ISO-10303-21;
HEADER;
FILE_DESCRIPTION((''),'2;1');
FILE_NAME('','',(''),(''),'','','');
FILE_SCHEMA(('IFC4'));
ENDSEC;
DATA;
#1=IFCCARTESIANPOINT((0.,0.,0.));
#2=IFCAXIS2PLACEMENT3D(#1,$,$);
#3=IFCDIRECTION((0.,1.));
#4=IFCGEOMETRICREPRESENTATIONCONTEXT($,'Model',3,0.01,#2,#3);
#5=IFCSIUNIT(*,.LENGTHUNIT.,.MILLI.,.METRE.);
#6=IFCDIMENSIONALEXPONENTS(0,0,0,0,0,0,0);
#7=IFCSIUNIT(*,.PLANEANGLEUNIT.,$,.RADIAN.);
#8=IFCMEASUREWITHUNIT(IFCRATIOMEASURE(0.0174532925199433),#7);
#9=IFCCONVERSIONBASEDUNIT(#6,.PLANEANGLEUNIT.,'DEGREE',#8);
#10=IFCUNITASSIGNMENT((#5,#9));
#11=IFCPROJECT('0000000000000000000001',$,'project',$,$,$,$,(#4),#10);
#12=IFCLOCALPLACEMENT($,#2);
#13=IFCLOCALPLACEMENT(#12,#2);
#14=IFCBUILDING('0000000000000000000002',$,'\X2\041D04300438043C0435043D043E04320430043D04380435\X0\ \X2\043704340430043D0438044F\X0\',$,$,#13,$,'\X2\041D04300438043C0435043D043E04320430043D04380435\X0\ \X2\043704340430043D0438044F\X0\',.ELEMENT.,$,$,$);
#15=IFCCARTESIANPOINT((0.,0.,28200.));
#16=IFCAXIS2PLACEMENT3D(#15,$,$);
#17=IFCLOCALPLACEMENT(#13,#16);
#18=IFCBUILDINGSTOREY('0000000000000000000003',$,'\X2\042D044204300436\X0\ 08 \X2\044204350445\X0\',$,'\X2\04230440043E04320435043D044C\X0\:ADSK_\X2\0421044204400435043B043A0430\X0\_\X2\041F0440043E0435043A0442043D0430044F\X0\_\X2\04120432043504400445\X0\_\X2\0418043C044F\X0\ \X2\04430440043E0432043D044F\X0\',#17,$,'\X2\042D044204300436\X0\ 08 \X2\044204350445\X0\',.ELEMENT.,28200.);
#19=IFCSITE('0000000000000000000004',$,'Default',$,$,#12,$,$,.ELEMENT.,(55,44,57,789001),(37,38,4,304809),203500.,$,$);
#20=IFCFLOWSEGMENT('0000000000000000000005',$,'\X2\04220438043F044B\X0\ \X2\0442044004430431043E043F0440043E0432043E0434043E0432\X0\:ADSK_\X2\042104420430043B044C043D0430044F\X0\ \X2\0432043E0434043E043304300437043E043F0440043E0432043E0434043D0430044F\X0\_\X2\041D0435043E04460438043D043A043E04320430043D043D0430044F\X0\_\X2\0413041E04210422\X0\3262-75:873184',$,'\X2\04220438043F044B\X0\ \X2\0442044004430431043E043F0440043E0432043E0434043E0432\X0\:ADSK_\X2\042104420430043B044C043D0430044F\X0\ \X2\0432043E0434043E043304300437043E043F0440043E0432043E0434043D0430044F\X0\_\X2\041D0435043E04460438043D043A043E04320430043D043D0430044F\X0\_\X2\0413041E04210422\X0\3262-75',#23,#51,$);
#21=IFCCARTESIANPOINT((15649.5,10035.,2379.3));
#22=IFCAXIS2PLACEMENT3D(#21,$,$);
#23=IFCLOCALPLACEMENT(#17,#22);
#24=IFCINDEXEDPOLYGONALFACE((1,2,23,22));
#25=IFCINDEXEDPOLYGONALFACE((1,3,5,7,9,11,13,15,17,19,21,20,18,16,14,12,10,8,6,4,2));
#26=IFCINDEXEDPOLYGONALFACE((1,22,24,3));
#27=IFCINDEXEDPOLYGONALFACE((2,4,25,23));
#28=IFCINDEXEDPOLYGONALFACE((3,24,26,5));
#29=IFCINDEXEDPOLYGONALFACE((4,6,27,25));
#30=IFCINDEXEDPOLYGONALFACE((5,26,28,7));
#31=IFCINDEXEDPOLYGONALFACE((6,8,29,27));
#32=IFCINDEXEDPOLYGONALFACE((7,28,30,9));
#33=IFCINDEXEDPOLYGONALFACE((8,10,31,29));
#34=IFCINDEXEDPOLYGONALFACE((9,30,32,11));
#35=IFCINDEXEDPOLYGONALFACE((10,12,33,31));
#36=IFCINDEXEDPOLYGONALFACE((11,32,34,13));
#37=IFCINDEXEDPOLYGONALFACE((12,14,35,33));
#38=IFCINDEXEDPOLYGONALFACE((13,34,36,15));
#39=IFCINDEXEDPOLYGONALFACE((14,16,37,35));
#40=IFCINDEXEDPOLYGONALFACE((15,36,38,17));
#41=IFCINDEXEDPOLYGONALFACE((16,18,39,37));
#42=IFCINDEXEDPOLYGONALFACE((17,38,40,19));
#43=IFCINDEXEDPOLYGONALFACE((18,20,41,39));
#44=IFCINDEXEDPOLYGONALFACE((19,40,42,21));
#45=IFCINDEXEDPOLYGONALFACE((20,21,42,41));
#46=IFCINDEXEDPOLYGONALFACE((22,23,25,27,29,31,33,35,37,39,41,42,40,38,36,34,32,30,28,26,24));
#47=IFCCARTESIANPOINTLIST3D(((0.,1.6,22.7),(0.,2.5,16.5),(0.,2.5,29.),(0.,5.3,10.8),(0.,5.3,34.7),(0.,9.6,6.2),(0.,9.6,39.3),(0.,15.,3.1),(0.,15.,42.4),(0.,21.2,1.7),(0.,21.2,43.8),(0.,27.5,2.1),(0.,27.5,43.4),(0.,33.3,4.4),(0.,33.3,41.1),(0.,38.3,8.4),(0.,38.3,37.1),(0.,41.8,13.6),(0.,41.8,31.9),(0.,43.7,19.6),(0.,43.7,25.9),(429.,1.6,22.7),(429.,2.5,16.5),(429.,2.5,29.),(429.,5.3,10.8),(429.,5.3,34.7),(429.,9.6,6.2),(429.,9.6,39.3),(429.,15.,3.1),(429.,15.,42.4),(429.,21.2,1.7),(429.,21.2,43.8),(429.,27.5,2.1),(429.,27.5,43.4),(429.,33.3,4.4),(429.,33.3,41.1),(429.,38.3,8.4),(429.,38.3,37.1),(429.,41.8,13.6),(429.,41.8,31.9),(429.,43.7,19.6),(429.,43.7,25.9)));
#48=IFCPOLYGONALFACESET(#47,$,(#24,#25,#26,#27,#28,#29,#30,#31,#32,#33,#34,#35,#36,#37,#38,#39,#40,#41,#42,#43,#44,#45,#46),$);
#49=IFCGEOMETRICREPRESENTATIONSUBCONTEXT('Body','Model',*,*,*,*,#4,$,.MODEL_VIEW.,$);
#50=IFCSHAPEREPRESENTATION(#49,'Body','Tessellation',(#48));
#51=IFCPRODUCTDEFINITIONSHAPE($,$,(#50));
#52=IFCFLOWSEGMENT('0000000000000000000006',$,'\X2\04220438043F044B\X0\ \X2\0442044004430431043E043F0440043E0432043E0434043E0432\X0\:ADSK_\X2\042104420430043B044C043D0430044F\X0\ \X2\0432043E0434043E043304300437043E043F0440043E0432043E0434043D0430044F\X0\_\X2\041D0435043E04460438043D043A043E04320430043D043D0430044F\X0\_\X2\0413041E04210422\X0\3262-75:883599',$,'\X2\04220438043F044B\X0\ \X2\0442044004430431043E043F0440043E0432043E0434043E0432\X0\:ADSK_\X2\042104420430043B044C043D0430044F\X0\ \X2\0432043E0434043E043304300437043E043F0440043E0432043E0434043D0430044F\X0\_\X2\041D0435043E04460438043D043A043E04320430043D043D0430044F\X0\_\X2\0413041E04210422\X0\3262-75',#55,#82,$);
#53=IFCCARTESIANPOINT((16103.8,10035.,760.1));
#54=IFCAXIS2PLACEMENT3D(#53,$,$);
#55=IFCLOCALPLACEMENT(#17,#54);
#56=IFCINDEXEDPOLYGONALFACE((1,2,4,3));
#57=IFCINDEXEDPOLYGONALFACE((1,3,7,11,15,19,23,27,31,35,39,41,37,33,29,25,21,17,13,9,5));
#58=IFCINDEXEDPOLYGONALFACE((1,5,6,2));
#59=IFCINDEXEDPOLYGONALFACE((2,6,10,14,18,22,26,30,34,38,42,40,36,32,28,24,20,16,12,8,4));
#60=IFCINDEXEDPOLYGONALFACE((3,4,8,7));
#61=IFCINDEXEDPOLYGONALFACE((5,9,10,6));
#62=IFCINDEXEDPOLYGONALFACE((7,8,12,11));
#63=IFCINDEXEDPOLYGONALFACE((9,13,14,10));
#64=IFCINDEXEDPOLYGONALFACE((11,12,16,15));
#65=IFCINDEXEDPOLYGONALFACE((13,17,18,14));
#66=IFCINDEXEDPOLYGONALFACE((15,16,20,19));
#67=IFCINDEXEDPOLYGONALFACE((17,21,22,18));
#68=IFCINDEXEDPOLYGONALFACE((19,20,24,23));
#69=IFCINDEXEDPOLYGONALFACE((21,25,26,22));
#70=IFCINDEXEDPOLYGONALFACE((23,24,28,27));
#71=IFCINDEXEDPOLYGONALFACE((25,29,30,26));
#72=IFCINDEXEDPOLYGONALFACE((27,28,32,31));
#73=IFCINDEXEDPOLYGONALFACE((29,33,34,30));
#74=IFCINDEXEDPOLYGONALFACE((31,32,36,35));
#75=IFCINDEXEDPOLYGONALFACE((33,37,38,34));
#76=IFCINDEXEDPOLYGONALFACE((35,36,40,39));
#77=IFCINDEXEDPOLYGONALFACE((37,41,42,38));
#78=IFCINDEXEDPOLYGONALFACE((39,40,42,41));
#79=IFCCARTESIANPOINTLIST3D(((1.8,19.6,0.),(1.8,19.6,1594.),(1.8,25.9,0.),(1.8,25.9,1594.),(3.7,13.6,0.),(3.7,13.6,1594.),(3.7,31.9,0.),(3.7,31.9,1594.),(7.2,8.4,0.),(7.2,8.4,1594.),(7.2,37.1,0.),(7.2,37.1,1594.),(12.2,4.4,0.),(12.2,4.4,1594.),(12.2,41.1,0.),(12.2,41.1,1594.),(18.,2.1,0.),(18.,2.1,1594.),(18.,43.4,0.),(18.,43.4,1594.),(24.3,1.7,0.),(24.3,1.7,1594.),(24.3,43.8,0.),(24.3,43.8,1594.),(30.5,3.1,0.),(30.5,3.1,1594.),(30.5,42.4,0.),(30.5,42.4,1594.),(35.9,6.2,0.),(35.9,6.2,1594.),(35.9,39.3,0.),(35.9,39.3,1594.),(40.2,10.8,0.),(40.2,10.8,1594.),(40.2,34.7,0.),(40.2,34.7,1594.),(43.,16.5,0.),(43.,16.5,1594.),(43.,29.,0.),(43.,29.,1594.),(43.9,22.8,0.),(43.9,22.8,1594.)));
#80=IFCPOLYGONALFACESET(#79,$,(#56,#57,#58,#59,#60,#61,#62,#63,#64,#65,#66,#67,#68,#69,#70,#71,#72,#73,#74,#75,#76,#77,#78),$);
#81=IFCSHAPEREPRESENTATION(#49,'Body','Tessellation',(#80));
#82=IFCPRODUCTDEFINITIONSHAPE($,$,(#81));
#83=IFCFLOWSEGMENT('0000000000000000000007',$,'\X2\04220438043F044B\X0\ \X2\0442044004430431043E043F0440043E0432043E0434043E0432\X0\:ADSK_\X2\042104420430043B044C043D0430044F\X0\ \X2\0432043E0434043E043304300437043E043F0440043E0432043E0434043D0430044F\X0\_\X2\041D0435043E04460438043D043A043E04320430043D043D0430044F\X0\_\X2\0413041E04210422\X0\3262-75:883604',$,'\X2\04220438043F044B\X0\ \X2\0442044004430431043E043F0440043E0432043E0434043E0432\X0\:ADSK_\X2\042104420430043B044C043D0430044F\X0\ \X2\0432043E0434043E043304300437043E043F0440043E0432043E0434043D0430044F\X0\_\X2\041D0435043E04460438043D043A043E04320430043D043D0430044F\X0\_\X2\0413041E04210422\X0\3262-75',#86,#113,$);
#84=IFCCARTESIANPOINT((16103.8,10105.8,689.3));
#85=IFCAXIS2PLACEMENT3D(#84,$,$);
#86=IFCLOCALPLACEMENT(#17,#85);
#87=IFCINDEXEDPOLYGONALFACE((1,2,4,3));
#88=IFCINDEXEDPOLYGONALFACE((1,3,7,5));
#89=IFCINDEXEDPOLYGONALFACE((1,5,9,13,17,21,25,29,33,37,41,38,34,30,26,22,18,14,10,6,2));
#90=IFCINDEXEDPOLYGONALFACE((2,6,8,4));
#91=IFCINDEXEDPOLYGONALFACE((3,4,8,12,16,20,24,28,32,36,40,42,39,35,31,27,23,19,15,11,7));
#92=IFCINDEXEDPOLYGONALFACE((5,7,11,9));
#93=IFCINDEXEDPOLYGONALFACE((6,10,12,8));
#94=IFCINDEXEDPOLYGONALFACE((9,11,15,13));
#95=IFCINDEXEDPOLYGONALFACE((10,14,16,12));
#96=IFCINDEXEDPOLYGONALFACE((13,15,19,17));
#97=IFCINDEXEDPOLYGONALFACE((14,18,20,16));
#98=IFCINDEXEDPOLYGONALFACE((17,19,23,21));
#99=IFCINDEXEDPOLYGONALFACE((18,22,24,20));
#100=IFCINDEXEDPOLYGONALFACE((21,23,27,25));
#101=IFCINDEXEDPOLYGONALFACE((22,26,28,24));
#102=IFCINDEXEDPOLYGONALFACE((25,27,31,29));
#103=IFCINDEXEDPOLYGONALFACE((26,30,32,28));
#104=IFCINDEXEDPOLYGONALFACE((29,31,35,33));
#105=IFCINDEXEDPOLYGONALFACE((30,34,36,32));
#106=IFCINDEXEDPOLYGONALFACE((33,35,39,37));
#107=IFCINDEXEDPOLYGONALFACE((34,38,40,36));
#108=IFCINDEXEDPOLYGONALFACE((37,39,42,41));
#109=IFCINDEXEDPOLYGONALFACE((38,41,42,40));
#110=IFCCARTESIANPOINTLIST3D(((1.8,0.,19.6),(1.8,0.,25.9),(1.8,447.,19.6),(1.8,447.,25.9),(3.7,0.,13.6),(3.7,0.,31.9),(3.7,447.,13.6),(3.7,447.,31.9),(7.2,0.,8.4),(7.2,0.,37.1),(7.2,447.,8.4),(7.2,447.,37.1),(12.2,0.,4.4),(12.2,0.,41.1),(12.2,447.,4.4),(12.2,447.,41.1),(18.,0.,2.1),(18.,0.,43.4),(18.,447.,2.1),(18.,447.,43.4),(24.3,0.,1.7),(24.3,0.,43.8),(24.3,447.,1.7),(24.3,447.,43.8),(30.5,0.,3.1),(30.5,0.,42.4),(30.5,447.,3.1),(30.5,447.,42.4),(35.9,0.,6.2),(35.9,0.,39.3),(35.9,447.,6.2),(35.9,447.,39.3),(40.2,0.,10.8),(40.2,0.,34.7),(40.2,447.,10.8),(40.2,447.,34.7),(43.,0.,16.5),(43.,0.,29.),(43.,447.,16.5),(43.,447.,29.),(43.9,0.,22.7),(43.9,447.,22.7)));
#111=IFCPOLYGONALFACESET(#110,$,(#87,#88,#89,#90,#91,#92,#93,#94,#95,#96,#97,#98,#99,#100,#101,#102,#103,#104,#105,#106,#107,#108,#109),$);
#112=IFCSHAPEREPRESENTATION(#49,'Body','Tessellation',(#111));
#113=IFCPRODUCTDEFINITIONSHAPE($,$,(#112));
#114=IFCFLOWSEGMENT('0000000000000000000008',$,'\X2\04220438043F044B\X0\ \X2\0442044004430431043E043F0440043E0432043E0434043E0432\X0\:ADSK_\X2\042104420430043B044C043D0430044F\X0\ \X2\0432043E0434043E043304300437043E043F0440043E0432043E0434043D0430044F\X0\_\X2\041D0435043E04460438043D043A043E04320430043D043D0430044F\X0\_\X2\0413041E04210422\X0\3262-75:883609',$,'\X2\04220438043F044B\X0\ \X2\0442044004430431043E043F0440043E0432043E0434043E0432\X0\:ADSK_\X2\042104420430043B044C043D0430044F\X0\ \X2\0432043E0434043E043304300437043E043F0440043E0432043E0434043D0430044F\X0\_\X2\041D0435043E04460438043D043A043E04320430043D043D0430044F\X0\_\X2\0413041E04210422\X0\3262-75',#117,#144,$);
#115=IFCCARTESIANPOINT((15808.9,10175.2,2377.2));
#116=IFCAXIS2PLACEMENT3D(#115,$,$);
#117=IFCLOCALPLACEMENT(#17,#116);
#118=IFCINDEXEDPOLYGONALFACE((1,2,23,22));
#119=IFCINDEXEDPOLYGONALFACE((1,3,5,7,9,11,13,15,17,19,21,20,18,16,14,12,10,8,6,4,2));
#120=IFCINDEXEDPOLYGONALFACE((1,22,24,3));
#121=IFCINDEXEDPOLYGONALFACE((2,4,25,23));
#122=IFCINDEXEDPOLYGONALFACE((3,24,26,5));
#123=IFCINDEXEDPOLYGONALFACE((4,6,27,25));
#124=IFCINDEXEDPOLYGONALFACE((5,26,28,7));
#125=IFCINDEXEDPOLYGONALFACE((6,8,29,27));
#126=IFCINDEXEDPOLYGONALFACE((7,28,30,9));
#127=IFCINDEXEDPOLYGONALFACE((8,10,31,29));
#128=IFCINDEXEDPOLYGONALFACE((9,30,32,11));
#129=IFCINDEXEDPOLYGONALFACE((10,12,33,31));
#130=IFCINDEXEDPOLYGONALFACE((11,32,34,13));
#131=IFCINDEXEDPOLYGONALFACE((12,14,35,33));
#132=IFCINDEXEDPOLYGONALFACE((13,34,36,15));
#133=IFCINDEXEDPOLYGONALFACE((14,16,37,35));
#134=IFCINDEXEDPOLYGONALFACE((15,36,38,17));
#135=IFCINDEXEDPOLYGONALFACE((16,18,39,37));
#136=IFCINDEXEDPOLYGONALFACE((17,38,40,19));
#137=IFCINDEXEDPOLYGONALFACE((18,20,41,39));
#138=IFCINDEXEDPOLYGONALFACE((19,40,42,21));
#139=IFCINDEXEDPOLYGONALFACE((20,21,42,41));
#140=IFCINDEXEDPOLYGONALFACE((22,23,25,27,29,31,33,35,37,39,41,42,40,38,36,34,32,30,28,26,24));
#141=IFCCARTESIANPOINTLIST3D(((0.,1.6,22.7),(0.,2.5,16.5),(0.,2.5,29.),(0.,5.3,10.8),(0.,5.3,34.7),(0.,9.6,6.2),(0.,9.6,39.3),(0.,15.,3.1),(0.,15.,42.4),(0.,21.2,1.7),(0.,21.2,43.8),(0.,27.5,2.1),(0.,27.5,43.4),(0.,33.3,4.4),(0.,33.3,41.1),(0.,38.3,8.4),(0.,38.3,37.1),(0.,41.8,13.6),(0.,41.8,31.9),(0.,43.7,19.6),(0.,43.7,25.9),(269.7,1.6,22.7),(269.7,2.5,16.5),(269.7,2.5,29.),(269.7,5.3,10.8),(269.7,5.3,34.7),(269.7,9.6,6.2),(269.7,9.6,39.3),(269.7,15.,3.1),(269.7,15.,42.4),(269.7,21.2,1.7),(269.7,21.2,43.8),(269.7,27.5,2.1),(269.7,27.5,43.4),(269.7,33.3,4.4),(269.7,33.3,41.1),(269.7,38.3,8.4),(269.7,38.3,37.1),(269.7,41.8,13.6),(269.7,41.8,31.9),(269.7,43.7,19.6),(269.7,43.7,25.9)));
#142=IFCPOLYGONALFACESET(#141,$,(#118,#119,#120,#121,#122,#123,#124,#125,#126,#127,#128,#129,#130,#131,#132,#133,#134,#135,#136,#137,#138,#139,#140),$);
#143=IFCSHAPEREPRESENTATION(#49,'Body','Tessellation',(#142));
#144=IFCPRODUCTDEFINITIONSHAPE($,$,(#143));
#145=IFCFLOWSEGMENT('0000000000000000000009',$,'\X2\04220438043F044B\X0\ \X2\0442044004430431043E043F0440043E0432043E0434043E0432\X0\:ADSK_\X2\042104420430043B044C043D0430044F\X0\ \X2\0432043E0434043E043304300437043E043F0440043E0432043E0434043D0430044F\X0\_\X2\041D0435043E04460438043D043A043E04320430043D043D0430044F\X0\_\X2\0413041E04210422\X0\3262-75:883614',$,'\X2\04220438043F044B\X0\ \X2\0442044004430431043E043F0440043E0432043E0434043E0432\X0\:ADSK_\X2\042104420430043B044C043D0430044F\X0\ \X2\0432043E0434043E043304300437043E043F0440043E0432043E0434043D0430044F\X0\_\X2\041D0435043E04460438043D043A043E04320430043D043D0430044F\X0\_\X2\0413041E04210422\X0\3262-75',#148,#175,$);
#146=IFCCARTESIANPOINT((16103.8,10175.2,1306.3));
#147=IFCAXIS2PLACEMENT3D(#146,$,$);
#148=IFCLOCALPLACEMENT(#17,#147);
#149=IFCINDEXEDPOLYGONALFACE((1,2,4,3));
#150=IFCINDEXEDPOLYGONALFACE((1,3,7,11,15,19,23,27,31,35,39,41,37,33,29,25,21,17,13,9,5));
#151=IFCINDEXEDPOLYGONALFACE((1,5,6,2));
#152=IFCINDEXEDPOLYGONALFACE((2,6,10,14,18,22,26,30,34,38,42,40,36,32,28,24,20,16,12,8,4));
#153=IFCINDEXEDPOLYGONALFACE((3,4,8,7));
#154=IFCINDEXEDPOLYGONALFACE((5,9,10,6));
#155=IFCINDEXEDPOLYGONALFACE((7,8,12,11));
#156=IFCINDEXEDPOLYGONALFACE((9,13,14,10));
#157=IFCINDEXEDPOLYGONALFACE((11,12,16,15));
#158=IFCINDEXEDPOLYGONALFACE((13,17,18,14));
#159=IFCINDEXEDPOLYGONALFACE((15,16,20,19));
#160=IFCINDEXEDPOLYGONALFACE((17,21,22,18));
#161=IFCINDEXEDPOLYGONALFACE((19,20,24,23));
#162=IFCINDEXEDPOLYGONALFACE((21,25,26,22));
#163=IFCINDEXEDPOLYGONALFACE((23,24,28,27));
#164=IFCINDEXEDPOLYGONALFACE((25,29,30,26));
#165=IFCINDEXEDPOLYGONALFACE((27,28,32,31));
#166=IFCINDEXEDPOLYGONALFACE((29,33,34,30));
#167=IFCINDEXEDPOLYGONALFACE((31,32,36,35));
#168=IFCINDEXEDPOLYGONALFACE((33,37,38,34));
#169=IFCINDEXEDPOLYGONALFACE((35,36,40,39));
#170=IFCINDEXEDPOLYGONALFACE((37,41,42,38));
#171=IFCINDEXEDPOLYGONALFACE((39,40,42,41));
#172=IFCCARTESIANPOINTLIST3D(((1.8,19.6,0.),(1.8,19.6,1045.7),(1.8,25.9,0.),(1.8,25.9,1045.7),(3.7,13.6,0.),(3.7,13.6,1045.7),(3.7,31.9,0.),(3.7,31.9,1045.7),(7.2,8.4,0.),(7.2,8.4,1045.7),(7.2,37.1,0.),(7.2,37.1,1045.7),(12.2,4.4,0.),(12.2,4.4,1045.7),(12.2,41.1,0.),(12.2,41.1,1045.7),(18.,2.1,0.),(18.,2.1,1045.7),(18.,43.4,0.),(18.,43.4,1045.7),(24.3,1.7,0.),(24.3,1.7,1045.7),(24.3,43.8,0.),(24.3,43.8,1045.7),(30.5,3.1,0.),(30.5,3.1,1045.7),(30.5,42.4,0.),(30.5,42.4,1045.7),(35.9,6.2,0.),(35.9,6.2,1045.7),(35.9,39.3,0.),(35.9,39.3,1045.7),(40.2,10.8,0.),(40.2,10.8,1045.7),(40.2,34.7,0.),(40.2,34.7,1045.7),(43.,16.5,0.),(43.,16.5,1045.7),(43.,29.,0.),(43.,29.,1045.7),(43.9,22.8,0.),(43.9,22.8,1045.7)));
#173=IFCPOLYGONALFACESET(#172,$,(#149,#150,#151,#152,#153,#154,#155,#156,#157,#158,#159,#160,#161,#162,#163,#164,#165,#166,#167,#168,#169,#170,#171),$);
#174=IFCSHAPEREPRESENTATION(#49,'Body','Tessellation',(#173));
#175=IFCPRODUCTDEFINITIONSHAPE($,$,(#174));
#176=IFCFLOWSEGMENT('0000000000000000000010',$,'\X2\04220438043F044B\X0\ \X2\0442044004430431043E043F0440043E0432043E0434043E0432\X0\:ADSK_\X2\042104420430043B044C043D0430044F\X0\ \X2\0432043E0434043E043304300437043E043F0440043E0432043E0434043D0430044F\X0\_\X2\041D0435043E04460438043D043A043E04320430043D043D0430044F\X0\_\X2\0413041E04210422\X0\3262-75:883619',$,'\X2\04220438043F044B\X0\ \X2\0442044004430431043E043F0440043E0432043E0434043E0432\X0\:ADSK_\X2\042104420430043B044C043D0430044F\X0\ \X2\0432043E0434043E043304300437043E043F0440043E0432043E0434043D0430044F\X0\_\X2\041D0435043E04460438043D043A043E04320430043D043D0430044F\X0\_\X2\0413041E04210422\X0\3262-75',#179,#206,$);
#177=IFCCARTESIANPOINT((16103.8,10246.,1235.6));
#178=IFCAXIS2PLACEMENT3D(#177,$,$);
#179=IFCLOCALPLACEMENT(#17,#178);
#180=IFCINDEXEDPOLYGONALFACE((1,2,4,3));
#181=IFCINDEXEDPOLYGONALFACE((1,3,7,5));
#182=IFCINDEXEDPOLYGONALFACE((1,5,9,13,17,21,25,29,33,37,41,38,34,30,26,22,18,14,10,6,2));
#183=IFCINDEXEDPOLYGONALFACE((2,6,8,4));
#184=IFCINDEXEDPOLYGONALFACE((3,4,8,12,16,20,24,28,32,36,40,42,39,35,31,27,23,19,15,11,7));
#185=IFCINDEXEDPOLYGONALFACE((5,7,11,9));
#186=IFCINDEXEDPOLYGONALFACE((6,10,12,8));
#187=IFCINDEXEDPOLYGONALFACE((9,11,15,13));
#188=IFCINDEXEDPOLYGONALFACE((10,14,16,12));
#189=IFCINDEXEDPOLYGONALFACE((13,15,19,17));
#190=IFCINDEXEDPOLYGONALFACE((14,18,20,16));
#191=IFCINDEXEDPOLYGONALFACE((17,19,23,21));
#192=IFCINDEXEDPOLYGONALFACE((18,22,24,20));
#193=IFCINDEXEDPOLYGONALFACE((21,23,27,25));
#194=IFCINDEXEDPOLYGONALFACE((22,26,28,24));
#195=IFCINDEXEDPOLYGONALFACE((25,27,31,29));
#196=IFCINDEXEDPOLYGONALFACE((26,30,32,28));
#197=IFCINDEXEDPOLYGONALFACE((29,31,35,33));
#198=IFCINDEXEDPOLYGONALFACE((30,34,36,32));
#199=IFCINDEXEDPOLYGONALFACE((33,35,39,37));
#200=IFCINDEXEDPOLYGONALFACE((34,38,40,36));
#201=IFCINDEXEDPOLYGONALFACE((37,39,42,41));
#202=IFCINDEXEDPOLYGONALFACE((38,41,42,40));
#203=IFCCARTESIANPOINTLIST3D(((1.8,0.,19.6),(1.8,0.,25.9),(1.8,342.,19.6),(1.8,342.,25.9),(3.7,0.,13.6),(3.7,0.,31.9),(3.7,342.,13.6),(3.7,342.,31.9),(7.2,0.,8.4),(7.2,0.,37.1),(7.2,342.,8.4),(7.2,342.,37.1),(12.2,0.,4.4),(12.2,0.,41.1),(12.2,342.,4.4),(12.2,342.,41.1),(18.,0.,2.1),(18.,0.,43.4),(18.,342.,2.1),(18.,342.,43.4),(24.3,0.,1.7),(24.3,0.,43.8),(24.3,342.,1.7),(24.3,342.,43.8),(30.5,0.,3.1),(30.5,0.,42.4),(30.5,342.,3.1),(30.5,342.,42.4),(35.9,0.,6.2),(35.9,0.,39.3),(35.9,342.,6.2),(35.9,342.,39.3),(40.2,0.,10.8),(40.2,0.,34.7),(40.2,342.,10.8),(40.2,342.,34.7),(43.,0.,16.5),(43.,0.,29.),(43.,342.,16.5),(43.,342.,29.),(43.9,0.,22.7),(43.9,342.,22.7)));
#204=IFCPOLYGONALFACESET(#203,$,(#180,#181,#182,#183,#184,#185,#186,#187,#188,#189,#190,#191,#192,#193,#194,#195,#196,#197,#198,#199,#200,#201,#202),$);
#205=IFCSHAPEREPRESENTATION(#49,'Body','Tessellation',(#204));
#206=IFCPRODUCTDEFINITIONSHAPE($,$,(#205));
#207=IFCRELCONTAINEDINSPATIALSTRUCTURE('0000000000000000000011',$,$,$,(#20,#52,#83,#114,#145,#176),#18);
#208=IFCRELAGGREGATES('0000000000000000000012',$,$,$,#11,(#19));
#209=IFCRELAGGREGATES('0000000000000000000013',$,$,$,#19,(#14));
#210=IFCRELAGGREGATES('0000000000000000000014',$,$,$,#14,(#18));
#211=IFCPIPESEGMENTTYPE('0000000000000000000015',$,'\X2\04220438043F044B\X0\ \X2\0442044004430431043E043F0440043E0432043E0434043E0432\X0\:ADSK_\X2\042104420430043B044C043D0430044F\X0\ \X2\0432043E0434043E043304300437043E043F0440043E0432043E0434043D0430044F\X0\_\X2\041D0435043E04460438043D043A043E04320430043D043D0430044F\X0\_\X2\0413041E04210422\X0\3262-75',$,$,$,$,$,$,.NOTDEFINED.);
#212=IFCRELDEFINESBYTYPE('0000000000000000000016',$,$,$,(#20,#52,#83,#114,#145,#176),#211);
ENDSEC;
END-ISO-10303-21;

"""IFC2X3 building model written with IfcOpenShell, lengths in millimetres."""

from ifc_helpers import new_model, entity, si_unit, converted_unit, direction, frame, origin, origin_2d_with_axis, place, context, subcontext, project, spatial, circle, extrude, type_object, element, save


model = new_model("IFC2X3")

# Units and contexts
model_context = context("Model", 3, precision=0.01, world=origin(), true_north=direction((0.0, 1.0)))
body_context = subcontext(model_context, "Body", "Model", "MODEL_VIEW")
ifc_project = project(units=[si_unit("LENGTHUNIT", "METRE", prefix="MILLI"), converted_unit("PLANEANGLEUNIT", "DEGREE", entity("IfcRatioMeasure", 0.0174532925199433), si_unit("PLANEANGLEUNIT", "RADIAN"), dimensions=[0, 0, 0, 0, 0, 0, 0])], contexts=[model_context])

# Site, building, storey
site_placement = place(None, origin())
site = spatial("IfcSite", under=ifc_project, at=site_placement, Name="Default", CompositionType="ELEMENT", RefLatitude=(55, 44, 57, 789001), RefLongitude=(37, 38, 4, 304809), RefElevation=203500.0)
building_placement = place(site_placement, origin())
building = spatial("IfcBuilding", under=site, at=building_placement, Name="Наименование здания", LongName="Наименование здания", CompositionType="ELEMENT")
storey_placement = place(building_placement, frame((0.0, 0.0, 28200.0)))
storey = spatial("IfcBuildingStorey", under=building, at=storey_placement, Name="Этаж 08 тех", ObjectType="Уровень:ADSK_Стрелка_Проектная_Вверх_Имя уровня", LongName="Этаж 08 тех", CompositionType="ELEMENT", Elevation=28200.0)

# Flow segments
pipe_segment_type = type_object("IfcPipeSegmentType", Name="Типы трубопроводов:ADSK_Стальная водогазопроводная_Неоцинкованная_ГОСТ3262-75", PredefinedType="NOTDEFINED")
flow_segment_1_placement = place(storey_placement, frame((15649.5, 10035.0, 2379.3)))
element("IfcFlowSegment", 1, at=flow_segment_1_placement, inside=storey, type_object=pipe_segment_type, Name="Типы трубопроводов:ADSK_Стальная водогазопроводная_Неоцинкованная_ГОСТ3262-75:873184", ObjectType="Типы трубопроводов:ADSK_Стальная водогазопроводная_Неоцинкованная_ГОСТ3262-75", context=body_context, shape_type="SweptSolid", body=[
    extrude(circle(Radius=21.1, at=origin_2d_with_axis()), frame((0.0, 22.8, 22.8), z_axis=(1.0, 0.0, 0.0), x_axis=(0.0, -1.0, 0.0)), (0.0, 0.0, 1.0), 429.0),
])
flow_segment_2_placement = place(storey_placement, frame((16103.8, 10035.0, 760.1)))
element("IfcFlowSegment", 2, at=flow_segment_2_placement, inside=storey, type_object=pipe_segment_type, Name="Типы трубопроводов:ADSK_Стальная водогазопроводная_Неоцинкованная_ГОСТ3262-75:883599", ObjectType="Типы трубопроводов:ADSK_Стальная водогазопроводная_Неоцинкованная_ГОСТ3262-75", context=body_context, shape_type="SweptSolid", body=[
    extrude(circle(Radius=21.1, at=origin_2d_with_axis()), frame((22.8, 22.8, 0.0)), (0.0, 0.0, 1.0), 1594.0),
])
flow_segment_3_placement = place(storey_placement, frame((16103.8, 10105.8, 689.3)))
element("IfcFlowSegment", 3, at=flow_segment_3_placement, inside=storey, type_object=pipe_segment_type, Name="Типы трубопроводов:ADSK_Стальная водогазопроводная_Неоцинкованная_ГОСТ3262-75:883604", ObjectType="Типы трубопроводов:ADSK_Стальная водогазопроводная_Неоцинкованная_ГОСТ3262-75", context=body_context, shape_type="SweptSolid", body=[
    extrude(circle(Radius=21.1, at=origin_2d_with_axis()), frame((22.8, 0.0, 22.8), z_axis=(0.0, 1.0, 0.0), x_axis=(1.0, 0.0, 0.0)), (0.0, 0.0, 1.0), 447.0),
])
flow_segment_4_placement = place(storey_placement, frame((15808.9, 10175.2, 2377.2)))
element("IfcFlowSegment", 4, at=flow_segment_4_placement, inside=storey, type_object=pipe_segment_type, Name="Типы трубопроводов:ADSK_Стальная водогазопроводная_Неоцинкованная_ГОСТ3262-75:883609", ObjectType="Типы трубопроводов:ADSK_Стальная водогазопроводная_Неоцинкованная_ГОСТ3262-75", context=body_context, shape_type="SweptSolid", body=[
    extrude(circle(Radius=21.1, at=origin_2d_with_axis()), frame((0.0, 22.8, 22.8), z_axis=(1.0, 0.0, 0.0), x_axis=(0.0, -1.0, 0.0)), (0.0, 0.0, 1.0), 269.7),
])
flow_segment_5_placement = place(storey_placement, frame((16103.8, 10175.2, 1306.3)))
element("IfcFlowSegment", 5, at=flow_segment_5_placement, inside=storey, type_object=pipe_segment_type, Name="Типы трубопроводов:ADSK_Стальная водогазопроводная_Неоцинкованная_ГОСТ3262-75:883614", ObjectType="Типы трубопроводов:ADSK_Стальная водогазопроводная_Неоцинкованная_ГОСТ3262-75", context=body_context, shape_type="SweptSolid", body=[
    extrude(circle(Radius=21.1, at=origin_2d_with_axis()), frame((22.8, 22.8, 0.0)), (0.0, 0.0, 1.0), 1045.7),
])
flow_segment_6_placement = place(storey_placement, frame((16103.8, 10246.0, 1235.6)))
element("IfcFlowSegment", 6, at=flow_segment_6_placement, inside=storey, type_object=pipe_segment_type, Name="Типы трубопроводов:ADSK_Стальная водогазопроводная_Неоцинкованная_ГОСТ3262-75:883619", ObjectType="Типы трубопроводов:ADSK_Стальная водогазопроводная_Неоцинкованная_ГОСТ3262-75", context=body_context, shape_type="SweptSolid", body=[
    extrude(circle(Radius=21.1, at=origin_2d_with_axis()), frame((22.8, 0.0, 22.8), z_axis=(0.0, 1.0, 0.0), x_axis=(1.0, 0.0, 0.0)), (0.0, 0.0, 1.0), 342.0),
])

save(model, "model.ifc")
